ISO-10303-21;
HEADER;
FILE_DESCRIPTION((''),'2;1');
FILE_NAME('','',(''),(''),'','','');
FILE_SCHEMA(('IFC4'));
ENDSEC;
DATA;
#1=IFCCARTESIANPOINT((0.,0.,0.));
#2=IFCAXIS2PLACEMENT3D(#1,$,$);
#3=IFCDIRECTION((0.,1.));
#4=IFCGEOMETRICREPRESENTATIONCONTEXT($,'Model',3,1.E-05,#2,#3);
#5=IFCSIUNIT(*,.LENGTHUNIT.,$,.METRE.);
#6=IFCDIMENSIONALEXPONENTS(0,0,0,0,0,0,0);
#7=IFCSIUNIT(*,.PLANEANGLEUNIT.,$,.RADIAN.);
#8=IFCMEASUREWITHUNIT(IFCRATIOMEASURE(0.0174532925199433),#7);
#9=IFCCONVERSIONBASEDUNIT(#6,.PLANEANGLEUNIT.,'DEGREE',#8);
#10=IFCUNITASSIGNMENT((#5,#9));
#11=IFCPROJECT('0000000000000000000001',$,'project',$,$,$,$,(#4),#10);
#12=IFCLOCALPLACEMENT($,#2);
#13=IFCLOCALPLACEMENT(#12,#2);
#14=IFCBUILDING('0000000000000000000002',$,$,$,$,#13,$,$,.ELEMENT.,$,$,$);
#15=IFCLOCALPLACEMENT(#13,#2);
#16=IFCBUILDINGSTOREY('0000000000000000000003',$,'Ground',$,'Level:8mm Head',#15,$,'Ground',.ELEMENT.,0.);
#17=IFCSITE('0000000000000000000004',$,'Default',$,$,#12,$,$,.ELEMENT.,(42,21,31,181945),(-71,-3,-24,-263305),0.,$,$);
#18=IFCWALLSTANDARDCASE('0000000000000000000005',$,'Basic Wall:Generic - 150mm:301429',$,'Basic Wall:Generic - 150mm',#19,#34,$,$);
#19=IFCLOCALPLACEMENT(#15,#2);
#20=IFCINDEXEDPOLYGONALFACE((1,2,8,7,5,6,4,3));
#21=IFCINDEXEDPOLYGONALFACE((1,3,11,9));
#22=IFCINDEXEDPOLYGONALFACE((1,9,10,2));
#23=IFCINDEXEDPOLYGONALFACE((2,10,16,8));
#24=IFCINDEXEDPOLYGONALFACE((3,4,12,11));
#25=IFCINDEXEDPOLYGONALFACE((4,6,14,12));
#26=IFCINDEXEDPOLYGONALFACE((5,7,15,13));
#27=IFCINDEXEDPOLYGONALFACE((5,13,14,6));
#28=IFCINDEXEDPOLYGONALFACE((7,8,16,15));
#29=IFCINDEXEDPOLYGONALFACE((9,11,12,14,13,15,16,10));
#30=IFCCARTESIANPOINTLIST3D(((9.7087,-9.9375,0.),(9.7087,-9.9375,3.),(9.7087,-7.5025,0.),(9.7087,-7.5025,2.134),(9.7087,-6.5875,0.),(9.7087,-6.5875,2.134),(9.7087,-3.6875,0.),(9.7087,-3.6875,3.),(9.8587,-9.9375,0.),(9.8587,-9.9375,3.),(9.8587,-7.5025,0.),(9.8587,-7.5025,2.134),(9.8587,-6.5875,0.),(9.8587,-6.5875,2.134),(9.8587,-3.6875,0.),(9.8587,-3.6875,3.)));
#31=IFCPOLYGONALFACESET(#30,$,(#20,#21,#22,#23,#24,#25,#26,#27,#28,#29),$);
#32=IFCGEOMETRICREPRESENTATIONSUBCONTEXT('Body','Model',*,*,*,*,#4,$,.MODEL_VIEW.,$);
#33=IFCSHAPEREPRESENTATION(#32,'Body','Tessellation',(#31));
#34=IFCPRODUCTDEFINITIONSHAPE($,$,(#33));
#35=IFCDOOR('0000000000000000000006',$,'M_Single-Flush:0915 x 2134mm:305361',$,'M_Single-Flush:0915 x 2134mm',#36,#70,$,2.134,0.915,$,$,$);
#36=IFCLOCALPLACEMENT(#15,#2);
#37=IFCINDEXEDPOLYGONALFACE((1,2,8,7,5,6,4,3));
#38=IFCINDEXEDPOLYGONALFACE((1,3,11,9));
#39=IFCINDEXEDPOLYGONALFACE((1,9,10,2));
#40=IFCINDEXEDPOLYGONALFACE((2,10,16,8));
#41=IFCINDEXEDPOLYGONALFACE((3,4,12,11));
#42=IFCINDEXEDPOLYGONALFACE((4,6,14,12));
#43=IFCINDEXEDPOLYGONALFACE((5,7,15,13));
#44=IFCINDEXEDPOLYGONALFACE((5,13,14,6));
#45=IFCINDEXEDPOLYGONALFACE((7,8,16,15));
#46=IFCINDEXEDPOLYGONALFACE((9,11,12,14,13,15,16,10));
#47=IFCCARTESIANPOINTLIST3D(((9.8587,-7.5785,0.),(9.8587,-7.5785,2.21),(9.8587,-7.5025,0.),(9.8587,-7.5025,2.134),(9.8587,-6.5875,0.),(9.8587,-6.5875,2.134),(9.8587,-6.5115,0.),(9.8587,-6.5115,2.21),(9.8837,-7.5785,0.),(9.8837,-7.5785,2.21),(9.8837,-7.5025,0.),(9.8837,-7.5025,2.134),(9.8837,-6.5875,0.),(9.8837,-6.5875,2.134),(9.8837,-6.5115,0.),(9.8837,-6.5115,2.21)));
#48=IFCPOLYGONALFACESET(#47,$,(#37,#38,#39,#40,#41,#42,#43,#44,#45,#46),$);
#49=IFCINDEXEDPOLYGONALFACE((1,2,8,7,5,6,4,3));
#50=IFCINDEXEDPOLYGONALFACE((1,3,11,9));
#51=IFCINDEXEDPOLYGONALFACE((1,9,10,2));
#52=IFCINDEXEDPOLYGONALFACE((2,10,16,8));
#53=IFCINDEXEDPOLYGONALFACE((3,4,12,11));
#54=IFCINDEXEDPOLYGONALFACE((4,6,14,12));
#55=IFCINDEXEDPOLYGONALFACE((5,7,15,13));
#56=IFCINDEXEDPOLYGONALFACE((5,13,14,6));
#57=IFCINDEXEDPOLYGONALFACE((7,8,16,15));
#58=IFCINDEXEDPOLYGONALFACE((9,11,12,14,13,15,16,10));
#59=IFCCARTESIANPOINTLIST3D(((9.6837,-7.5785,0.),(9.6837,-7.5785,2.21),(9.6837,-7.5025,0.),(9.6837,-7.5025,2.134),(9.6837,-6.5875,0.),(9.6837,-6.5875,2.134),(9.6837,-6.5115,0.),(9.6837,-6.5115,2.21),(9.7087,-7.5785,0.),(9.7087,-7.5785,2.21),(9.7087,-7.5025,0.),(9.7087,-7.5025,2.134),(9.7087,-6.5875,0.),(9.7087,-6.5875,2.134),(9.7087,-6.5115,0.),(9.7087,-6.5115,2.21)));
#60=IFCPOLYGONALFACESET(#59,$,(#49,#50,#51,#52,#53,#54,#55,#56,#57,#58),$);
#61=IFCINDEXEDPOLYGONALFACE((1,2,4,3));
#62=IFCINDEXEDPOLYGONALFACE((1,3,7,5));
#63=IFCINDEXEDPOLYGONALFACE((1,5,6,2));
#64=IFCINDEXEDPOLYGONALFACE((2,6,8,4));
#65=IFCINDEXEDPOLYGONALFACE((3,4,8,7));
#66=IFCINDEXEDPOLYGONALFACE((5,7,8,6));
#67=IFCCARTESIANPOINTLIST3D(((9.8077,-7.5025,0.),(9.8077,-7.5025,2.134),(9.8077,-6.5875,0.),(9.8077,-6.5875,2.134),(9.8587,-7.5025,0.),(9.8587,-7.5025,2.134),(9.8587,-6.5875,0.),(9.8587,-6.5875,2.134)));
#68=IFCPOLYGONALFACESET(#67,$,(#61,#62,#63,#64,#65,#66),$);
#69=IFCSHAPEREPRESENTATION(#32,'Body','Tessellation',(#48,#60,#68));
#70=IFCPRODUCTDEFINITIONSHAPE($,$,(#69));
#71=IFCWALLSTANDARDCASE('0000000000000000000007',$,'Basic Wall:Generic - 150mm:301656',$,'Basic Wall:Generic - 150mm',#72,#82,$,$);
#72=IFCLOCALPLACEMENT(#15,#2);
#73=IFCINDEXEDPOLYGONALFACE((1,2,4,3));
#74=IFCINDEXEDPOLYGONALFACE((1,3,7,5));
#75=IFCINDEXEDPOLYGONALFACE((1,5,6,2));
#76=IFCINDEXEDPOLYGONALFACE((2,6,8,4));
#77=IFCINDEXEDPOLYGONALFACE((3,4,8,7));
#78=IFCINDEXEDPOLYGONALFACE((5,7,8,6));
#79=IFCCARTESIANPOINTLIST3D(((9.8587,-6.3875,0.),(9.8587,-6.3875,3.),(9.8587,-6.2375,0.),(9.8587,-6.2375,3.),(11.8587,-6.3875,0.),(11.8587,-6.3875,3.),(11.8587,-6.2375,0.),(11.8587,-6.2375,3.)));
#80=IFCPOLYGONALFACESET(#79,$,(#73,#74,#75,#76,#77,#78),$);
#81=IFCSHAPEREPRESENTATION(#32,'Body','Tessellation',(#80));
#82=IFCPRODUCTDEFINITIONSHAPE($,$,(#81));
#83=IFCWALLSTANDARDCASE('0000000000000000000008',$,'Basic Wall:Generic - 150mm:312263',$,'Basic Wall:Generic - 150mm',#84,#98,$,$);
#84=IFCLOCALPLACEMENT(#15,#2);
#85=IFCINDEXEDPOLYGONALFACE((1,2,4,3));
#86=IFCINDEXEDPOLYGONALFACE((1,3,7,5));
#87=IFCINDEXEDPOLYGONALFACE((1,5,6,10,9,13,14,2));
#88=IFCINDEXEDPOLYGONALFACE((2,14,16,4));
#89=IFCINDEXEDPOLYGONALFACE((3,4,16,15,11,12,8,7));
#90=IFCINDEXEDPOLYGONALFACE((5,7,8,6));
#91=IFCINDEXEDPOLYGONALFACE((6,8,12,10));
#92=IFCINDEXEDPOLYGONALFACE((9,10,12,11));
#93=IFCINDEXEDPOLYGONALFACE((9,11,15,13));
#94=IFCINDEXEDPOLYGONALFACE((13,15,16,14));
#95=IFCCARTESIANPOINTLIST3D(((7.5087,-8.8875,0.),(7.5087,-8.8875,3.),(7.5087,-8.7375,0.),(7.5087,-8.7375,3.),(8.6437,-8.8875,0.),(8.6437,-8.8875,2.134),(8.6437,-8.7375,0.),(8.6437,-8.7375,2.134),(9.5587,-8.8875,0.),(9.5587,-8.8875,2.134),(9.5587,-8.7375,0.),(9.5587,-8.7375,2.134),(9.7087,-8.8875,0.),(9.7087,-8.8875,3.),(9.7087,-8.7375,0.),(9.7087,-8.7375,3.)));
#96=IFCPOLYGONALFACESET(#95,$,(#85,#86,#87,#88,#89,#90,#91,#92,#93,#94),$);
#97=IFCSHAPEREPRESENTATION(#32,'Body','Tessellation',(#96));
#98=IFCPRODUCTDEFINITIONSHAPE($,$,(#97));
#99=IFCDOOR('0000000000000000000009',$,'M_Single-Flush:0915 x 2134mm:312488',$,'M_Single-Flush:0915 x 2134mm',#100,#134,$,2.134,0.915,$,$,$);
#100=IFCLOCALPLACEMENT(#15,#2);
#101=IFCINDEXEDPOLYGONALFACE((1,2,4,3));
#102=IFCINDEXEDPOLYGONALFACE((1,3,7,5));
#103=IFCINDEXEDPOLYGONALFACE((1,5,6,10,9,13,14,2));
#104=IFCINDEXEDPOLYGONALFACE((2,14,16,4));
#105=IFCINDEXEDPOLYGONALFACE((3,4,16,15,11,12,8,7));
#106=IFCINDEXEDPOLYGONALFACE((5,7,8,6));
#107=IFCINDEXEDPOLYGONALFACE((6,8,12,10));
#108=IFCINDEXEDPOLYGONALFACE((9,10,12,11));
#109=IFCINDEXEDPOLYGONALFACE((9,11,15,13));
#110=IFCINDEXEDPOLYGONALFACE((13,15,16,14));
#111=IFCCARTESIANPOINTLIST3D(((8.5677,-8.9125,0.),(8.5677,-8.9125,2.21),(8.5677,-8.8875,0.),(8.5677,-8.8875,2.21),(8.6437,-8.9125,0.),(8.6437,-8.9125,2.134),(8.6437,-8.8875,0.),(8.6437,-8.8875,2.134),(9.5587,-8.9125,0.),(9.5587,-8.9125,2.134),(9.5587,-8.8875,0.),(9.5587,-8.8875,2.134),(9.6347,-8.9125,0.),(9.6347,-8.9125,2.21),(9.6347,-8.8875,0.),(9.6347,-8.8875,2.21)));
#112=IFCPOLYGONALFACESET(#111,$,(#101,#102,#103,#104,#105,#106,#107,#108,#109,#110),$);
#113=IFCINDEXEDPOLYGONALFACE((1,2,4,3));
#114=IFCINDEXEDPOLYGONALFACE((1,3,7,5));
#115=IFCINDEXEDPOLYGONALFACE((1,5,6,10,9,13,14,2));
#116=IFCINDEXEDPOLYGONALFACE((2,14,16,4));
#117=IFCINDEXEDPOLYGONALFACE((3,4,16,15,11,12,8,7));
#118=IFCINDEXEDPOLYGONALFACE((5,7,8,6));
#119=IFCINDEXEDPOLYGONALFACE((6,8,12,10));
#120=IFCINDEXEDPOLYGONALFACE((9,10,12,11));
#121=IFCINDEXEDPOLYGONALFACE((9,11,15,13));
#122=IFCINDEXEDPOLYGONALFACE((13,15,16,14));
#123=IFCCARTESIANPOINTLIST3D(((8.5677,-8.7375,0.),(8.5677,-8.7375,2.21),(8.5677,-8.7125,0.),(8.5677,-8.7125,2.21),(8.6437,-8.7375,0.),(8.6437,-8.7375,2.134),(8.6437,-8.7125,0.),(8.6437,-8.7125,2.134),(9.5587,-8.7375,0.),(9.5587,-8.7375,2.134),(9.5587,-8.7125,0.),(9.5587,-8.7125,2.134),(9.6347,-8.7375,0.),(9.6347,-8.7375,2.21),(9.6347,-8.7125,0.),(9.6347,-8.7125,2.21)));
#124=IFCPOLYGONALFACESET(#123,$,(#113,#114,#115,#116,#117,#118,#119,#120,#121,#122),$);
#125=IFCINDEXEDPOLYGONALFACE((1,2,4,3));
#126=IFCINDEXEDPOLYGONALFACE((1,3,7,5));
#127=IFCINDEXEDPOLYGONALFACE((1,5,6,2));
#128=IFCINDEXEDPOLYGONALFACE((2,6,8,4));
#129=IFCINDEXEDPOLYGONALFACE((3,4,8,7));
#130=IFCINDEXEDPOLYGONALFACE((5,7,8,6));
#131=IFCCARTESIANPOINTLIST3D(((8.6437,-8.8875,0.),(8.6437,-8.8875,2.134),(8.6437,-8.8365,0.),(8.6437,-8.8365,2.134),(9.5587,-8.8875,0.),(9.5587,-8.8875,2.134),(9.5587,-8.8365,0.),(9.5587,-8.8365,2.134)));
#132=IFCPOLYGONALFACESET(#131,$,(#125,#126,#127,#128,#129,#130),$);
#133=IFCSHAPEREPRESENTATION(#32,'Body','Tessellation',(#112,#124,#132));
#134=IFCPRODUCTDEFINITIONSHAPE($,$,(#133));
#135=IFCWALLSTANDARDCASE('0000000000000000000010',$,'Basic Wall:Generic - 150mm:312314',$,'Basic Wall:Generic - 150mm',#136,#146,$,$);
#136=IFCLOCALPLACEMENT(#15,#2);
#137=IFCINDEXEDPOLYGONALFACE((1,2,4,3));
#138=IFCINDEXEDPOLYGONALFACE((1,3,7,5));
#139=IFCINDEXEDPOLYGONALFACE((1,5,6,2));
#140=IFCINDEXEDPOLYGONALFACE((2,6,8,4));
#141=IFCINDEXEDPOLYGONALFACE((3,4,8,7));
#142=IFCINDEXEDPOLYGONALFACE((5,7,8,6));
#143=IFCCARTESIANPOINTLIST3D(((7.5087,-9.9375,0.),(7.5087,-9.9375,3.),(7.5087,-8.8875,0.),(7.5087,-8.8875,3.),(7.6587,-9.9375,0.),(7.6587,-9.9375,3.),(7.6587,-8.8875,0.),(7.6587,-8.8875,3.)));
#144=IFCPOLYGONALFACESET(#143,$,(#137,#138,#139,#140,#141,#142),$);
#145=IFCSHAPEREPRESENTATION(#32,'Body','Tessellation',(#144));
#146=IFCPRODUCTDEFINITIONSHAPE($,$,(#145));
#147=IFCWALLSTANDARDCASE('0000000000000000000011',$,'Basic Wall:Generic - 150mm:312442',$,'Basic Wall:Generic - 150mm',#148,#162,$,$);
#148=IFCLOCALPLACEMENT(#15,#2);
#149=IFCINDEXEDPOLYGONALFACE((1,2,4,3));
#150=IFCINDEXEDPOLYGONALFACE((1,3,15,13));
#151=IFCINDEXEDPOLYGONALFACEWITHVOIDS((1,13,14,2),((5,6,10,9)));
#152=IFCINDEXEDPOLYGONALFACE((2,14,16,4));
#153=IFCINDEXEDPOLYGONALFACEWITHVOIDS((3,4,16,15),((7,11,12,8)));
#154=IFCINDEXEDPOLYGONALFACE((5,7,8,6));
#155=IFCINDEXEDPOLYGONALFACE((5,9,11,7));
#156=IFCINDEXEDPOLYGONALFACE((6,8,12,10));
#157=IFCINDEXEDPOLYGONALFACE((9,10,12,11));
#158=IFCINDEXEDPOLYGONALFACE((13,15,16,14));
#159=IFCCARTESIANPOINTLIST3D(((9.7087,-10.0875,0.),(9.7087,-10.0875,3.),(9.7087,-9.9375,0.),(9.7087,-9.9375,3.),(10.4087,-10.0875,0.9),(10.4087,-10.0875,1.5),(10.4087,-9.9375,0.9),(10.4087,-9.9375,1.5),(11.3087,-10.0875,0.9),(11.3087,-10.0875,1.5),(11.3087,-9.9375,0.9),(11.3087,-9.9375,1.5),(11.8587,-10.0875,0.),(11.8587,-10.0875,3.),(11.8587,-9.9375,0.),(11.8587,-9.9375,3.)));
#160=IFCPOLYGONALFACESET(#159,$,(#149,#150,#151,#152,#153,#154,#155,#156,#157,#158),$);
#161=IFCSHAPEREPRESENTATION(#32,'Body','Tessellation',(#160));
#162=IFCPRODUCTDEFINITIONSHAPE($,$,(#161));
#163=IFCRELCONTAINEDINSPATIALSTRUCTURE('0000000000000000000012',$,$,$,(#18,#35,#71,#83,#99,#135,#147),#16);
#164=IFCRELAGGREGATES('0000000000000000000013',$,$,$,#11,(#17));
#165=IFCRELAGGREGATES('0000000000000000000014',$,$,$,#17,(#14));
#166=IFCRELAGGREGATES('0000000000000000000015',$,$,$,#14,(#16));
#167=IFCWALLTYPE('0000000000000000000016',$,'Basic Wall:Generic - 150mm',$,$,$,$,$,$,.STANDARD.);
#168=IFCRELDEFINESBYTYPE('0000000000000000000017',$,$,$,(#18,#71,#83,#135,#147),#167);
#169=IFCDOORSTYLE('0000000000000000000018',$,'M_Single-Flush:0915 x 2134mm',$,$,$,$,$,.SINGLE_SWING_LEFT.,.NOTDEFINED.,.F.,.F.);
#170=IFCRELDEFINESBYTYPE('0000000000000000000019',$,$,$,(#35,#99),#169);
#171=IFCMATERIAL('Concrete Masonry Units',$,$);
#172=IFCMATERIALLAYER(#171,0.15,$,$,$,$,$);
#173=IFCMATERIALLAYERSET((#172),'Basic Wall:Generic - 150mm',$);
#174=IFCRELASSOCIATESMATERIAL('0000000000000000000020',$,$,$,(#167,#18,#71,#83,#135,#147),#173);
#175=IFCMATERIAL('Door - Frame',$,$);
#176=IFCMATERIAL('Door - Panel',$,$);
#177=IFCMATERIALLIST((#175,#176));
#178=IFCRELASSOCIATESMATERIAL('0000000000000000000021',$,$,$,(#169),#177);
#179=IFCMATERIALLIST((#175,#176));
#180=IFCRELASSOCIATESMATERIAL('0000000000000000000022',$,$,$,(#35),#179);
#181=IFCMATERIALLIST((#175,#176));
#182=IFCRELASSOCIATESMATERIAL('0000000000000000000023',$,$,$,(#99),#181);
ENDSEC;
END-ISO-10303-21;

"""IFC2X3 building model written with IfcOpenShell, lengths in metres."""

from ifc_helpers import new_model, entity, si_unit, converted_unit, direction, frame, frame_2d, origin, place, context, subcontext, project, spatial, polyline, rectangle, outline, extrude, source, transform, mapped, material, material_list, layer, layer_set, layer_usage, type_object, type_shapes, element, fill, save


model = new_model("IFC2X3")

# Units and contexts
model_context = context("Model", 3, precision=1e-05, world=origin(), true_north=direction((0.0, 1.0)))
body_context = subcontext(model_context, "Body", "Model", "MODEL_VIEW")
ifc_project = project(units=[si_unit("LENGTHUNIT", "METRE"), converted_unit("PLANEANGLEUNIT", "DEGREE", entity("IfcRatioMeasure", 0.0174532925199433), si_unit("PLANEANGLEUNIT", "RADIAN"), dimensions=[0, 0, 0, 0, 0, 0, 0])], contexts=[model_context])

# Site, building, storey
site_placement = place(None, origin())
site = spatial("IfcSite", under=ifc_project, at=site_placement, Name="Default", CompositionType="ELEMENT", RefLatitude=(42, 21, 31, 181945), RefLongitude=(-71, -3, -24, -263305), RefElevation=0.0)
building_placement = place(site_placement, origin())
building = spatial("IfcBuilding", under=site, at=building_placement, CompositionType="ELEMENT")
storey_placement = place(building_placement, origin())
storey = spatial("IfcBuildingStorey", under=building, at=storey_placement, Name="Ground", ObjectType="Level:8mm Head", LongName="Ground", CompositionType="ELEMENT", Elevation=0.0)

# Shared definitions
ifc_material_1 = material(Name="Concrete Masonry Units")
ifc_layer = layer(ifc_material_1, 0.15)
ifc_layer_set = layer_set([ifc_layer], Name="Basic Wall:Generic - 150mm")
wall_type = type_object("IfcWallType", Name="Basic Wall:Generic - 150mm", PredefinedType="STANDARD", material=ifc_layer_set)
ifc_material_2 = material(Name="Door - Frame")
ifc_material_3 = material(Name="Door - Panel")

# Shared definitions
ifc_material_list_1 = material_list([ifc_material_2, ifc_material_3])
door_style_1 = type_object("IfcDoorStyle", Name="M_Single-Flush:0915 x 2134mm", ConstructionType="NOTDEFINED", OperationType="SINGLE_SWING_LEFT", ParameterTakesPrecedence=False, Sizeable=False, material=ifc_material_list_1)
shared_shape_1 = source(origin(), body_context, "Body", "SweptSolid", [
    extrude(outline(polyline([(-0.5335, -1.124), (0.5335, -1.124), (0.5335, 1.086), (0.4575, 1.086), (0.4575, -1.048), (-0.4575, -1.048), (-0.4575, 1.086), (-0.5335, 1.086), (-0.5335, -1.124)])), frame((0.4575, 0.175, 1.086), z_axis=(0.0, -1.0, 0.0), x_axis=(-1.0, 0.0, 0.0)), (0.0, 0.0, 1.0), 0.025),
    extrude(outline(polyline([(-1.124, -0.5335), (1.086, -0.5335), (1.086, -0.4575), (-1.048, -0.4575), (-1.048, 0.4575), (1.086, 0.4575), (1.086, 0.5335), (-1.124, 0.5335), (-1.124, -0.5335)])), frame((0.4575, 0.0, 1.086), z_axis=(0.0, -1.0, 0.0), x_axis=(0.0, 0.0, -1.0)), (0.0, 0.0, 1.0), 0.025),
    extrude(rectangle(XDim=0.915, YDim=0.051, at=frame_2d((0.0, 0.0), x_axis=(1.0, 0.0))), frame((0.4575, 0.1245, 0.0)), (0.0, 0.0, 1.0), 2.134),
])
type_shapes(door_style_1, [shared_shape_1])

# Wall, opening, door
ifc_layer_usage_1 = layer_usage(ifc_layer_set, "AXIS2", "NEGATIVE", 0.075)
wall_1_placement = place(storey_placement, frame((9.7837, -3.6875, 0.0), z_axis=(0.0, 0.0, 1.0), x_axis=(0.0, -1.0, 0.0)))
wall_1 = element("IfcWallStandardCase", 1, at=wall_1_placement, inside=storey, type_object=wall_type, material=ifc_layer_usage_1, Name="Basic Wall:Generic - 150mm:301429", ObjectType="Basic Wall:Generic - 150mm", context=body_context, shape_type="SweptSolid", body=[
    extrude(rectangle(XDim=6.25, YDim=0.15, at=frame_2d((3.125, 0.0), x_axis=(-1.0, 0.0))), origin(), (0.0, 0.0, 1.0), 3.0),
])
opening_1_placement = place(wall_1_placement, frame((2.9, -0.075, 0.0)))
opening_1 = element("IfcOpeningElement", 2, at=opening_1_placement, cuts=wall_1, ObjectType="Opening", context=body_context, shape_type="SweptSolid", body=[
    extrude(rectangle(XDim=0.915, YDim=2.134, at=frame_2d((1.067, 0.4575), x_axis=(0.0, -1.0))), frame((0.0, 0.0, 0.0), z_axis=(0.0, 1.0, 0.0), x_axis=(0.0, 0.0, 1.0)), (0.0, 0.0, 1.0), 0.15),
])
ifc_material_list_2 = material_list([ifc_material_2, ifc_material_3])
door_1_placement = place(opening_1_placement, origin())
door_1 = element("IfcDoor", 3, at=door_1_placement, inside=storey, type_object=door_style_1, material=ifc_material_list_2, Name="M_Single-Flush:0915 x 2134mm:305361", ObjectType="M_Single-Flush:0915 x 2134mm", OverallHeight=2.134, OverallWidth=0.915, context=body_context, shape_type="MappedRepresentation", body=[
    mapped(shared_shape_1, transform((0.0, 0.0, 0.0), scale=1.0)),
])
fill(opening_1, door_1)

# Wall
ifc_layer_usage_2 = layer_usage(ifc_layer_set, "AXIS2", "POSITIVE", -0.075)
wall_2_placement = place(storey_placement, frame((9.8587, -6.3125, 0.0)))
element("IfcWallStandardCase", 4, at=wall_2_placement, inside=storey, type_object=wall_type, material=ifc_layer_usage_2, Name="Basic Wall:Generic - 150mm:301656", ObjectType="Basic Wall:Generic - 150mm", context=body_context, shape_type="SweptSolid", body=[
    extrude(rectangle(XDim=2.0, YDim=0.15, at=frame_2d((1.0, 0.0), x_axis=(-1.0, 0.0))), origin(), (0.0, 0.0, 1.0), 3.0),
])

# Wall, opening, door
ifc_layer_usage_3 = layer_usage(ifc_layer_set, "AXIS2", "NEGATIVE", 0.075)
wall_3_placement = place(storey_placement, frame((9.7087, -8.8125, 0.0), z_axis=(0.0, 0.0, 1.0), x_axis=(-1.0, 0.0, 0.0)))
wall_3 = element("IfcWallStandardCase", 5, at=wall_3_placement, inside=storey, type_object=wall_type, material=ifc_layer_usage_3, Name="Basic Wall:Generic - 150mm:312263", ObjectType="Basic Wall:Generic - 150mm", context=body_context, shape_type="SweptSolid", body=[
    extrude(rectangle(XDim=2.2, YDim=0.15, at=frame_2d((1.1, 0.0), x_axis=(-1.0, 0.0))), origin(), (0.0, 0.0, 1.0), 3.0),
])
opening_2_placement = place(wall_3_placement, frame((0.15, -0.075, 0.0)))
opening_2 = element("IfcOpeningElement", 6, at=opening_2_placement, cuts=wall_3, ObjectType="Opening", context=body_context, shape_type="SweptSolid", body=[
    extrude(rectangle(XDim=0.915, YDim=2.134, at=frame_2d((1.067, 0.4575), x_axis=(0.0, -1.0))), frame((0.0, 0.0, 0.0), z_axis=(0.0, 1.0, 0.0), x_axis=(0.0, 0.0, 1.0)), (0.0, 0.0, 1.0), 0.15),
])
ifc_material_list_3 = material_list([ifc_material_2, ifc_material_3])
door_2_placement = place(opening_2_placement, origin())
door_2 = element("IfcDoor", 7, at=door_2_placement, inside=storey, type_object=door_style_1, material=ifc_material_list_3, Name="M_Single-Flush:0915 x 2134mm:312488", ObjectType="M_Single-Flush:0915 x 2134mm", OverallHeight=2.134, OverallWidth=0.915, context=body_context, shape_type="MappedRepresentation", body=[
    mapped(shared_shape_1, transform((0.0, 0.0, 0.0), scale=1.0)),
])
fill(opening_2, door_2)

# Wall
ifc_layer_usage_4 = layer_usage(ifc_layer_set, "AXIS2", "NEGATIVE", 0.075)
wall_4_placement = place(storey_placement, frame((7.5837, -8.8875, 0.0), z_axis=(0.0, 0.0, 1.0), x_axis=(0.0, -1.0, 0.0)))
element("IfcWallStandardCase", 8, at=wall_4_placement, inside=storey, type_object=wall_type, material=ifc_layer_usage_4, Name="Basic Wall:Generic - 150mm:312314", ObjectType="Basic Wall:Generic - 150mm", context=body_context, shape_type="SweptSolid", body=[
    extrude(rectangle(XDim=1.05, YDim=0.15, at=frame_2d((0.525, 0.0), x_axis=(-1.0, 0.0))), origin(), (0.0, 0.0, 1.0), 3.0),
])

# Wall, opening
ifc_layer_usage_5 = layer_usage(ifc_layer_set, "AXIS2", "POSITIVE", -0.075)
wall_5_placement = place(storey_placement, frame((9.7087, -10.0125, 0.0)))
wall_5 = element("IfcWallStandardCase", 9, at=wall_5_placement, inside=storey, type_object=wall_type, material=ifc_layer_usage_5, Name="Basic Wall:Generic - 150mm:312442", ObjectType="Basic Wall:Generic - 150mm", context=body_context, shape_type="SweptSolid", body=[
    extrude(rectangle(XDim=2.15, YDim=0.15, at=frame_2d((1.075, 0.0), x_axis=(-1.0, 0.0))), origin(), (0.0, 0.0, 1.0), 3.0),
])
opening_3_placement = place(wall_5_placement, frame((0.7, -0.075, 0.9)))
element("IfcOpeningElement", 10, at=opening_3_placement, cuts=wall_5, ObjectType="Opening", context=body_context, shape_type="SweptSolid", body=[
    extrude(rectangle(XDim=0.6, YDim=0.9, at=frame_2d((0.3, 0.45), x_axis=(-1.0, 0.0))), frame((0.0, 0.0, 0.0), z_axis=(0.0, 1.0, 0.0), x_axis=(0.0, 0.0, 1.0)), (0.0, 0.0, 1.0), 0.15),
])

save(model, "model.ifc")
